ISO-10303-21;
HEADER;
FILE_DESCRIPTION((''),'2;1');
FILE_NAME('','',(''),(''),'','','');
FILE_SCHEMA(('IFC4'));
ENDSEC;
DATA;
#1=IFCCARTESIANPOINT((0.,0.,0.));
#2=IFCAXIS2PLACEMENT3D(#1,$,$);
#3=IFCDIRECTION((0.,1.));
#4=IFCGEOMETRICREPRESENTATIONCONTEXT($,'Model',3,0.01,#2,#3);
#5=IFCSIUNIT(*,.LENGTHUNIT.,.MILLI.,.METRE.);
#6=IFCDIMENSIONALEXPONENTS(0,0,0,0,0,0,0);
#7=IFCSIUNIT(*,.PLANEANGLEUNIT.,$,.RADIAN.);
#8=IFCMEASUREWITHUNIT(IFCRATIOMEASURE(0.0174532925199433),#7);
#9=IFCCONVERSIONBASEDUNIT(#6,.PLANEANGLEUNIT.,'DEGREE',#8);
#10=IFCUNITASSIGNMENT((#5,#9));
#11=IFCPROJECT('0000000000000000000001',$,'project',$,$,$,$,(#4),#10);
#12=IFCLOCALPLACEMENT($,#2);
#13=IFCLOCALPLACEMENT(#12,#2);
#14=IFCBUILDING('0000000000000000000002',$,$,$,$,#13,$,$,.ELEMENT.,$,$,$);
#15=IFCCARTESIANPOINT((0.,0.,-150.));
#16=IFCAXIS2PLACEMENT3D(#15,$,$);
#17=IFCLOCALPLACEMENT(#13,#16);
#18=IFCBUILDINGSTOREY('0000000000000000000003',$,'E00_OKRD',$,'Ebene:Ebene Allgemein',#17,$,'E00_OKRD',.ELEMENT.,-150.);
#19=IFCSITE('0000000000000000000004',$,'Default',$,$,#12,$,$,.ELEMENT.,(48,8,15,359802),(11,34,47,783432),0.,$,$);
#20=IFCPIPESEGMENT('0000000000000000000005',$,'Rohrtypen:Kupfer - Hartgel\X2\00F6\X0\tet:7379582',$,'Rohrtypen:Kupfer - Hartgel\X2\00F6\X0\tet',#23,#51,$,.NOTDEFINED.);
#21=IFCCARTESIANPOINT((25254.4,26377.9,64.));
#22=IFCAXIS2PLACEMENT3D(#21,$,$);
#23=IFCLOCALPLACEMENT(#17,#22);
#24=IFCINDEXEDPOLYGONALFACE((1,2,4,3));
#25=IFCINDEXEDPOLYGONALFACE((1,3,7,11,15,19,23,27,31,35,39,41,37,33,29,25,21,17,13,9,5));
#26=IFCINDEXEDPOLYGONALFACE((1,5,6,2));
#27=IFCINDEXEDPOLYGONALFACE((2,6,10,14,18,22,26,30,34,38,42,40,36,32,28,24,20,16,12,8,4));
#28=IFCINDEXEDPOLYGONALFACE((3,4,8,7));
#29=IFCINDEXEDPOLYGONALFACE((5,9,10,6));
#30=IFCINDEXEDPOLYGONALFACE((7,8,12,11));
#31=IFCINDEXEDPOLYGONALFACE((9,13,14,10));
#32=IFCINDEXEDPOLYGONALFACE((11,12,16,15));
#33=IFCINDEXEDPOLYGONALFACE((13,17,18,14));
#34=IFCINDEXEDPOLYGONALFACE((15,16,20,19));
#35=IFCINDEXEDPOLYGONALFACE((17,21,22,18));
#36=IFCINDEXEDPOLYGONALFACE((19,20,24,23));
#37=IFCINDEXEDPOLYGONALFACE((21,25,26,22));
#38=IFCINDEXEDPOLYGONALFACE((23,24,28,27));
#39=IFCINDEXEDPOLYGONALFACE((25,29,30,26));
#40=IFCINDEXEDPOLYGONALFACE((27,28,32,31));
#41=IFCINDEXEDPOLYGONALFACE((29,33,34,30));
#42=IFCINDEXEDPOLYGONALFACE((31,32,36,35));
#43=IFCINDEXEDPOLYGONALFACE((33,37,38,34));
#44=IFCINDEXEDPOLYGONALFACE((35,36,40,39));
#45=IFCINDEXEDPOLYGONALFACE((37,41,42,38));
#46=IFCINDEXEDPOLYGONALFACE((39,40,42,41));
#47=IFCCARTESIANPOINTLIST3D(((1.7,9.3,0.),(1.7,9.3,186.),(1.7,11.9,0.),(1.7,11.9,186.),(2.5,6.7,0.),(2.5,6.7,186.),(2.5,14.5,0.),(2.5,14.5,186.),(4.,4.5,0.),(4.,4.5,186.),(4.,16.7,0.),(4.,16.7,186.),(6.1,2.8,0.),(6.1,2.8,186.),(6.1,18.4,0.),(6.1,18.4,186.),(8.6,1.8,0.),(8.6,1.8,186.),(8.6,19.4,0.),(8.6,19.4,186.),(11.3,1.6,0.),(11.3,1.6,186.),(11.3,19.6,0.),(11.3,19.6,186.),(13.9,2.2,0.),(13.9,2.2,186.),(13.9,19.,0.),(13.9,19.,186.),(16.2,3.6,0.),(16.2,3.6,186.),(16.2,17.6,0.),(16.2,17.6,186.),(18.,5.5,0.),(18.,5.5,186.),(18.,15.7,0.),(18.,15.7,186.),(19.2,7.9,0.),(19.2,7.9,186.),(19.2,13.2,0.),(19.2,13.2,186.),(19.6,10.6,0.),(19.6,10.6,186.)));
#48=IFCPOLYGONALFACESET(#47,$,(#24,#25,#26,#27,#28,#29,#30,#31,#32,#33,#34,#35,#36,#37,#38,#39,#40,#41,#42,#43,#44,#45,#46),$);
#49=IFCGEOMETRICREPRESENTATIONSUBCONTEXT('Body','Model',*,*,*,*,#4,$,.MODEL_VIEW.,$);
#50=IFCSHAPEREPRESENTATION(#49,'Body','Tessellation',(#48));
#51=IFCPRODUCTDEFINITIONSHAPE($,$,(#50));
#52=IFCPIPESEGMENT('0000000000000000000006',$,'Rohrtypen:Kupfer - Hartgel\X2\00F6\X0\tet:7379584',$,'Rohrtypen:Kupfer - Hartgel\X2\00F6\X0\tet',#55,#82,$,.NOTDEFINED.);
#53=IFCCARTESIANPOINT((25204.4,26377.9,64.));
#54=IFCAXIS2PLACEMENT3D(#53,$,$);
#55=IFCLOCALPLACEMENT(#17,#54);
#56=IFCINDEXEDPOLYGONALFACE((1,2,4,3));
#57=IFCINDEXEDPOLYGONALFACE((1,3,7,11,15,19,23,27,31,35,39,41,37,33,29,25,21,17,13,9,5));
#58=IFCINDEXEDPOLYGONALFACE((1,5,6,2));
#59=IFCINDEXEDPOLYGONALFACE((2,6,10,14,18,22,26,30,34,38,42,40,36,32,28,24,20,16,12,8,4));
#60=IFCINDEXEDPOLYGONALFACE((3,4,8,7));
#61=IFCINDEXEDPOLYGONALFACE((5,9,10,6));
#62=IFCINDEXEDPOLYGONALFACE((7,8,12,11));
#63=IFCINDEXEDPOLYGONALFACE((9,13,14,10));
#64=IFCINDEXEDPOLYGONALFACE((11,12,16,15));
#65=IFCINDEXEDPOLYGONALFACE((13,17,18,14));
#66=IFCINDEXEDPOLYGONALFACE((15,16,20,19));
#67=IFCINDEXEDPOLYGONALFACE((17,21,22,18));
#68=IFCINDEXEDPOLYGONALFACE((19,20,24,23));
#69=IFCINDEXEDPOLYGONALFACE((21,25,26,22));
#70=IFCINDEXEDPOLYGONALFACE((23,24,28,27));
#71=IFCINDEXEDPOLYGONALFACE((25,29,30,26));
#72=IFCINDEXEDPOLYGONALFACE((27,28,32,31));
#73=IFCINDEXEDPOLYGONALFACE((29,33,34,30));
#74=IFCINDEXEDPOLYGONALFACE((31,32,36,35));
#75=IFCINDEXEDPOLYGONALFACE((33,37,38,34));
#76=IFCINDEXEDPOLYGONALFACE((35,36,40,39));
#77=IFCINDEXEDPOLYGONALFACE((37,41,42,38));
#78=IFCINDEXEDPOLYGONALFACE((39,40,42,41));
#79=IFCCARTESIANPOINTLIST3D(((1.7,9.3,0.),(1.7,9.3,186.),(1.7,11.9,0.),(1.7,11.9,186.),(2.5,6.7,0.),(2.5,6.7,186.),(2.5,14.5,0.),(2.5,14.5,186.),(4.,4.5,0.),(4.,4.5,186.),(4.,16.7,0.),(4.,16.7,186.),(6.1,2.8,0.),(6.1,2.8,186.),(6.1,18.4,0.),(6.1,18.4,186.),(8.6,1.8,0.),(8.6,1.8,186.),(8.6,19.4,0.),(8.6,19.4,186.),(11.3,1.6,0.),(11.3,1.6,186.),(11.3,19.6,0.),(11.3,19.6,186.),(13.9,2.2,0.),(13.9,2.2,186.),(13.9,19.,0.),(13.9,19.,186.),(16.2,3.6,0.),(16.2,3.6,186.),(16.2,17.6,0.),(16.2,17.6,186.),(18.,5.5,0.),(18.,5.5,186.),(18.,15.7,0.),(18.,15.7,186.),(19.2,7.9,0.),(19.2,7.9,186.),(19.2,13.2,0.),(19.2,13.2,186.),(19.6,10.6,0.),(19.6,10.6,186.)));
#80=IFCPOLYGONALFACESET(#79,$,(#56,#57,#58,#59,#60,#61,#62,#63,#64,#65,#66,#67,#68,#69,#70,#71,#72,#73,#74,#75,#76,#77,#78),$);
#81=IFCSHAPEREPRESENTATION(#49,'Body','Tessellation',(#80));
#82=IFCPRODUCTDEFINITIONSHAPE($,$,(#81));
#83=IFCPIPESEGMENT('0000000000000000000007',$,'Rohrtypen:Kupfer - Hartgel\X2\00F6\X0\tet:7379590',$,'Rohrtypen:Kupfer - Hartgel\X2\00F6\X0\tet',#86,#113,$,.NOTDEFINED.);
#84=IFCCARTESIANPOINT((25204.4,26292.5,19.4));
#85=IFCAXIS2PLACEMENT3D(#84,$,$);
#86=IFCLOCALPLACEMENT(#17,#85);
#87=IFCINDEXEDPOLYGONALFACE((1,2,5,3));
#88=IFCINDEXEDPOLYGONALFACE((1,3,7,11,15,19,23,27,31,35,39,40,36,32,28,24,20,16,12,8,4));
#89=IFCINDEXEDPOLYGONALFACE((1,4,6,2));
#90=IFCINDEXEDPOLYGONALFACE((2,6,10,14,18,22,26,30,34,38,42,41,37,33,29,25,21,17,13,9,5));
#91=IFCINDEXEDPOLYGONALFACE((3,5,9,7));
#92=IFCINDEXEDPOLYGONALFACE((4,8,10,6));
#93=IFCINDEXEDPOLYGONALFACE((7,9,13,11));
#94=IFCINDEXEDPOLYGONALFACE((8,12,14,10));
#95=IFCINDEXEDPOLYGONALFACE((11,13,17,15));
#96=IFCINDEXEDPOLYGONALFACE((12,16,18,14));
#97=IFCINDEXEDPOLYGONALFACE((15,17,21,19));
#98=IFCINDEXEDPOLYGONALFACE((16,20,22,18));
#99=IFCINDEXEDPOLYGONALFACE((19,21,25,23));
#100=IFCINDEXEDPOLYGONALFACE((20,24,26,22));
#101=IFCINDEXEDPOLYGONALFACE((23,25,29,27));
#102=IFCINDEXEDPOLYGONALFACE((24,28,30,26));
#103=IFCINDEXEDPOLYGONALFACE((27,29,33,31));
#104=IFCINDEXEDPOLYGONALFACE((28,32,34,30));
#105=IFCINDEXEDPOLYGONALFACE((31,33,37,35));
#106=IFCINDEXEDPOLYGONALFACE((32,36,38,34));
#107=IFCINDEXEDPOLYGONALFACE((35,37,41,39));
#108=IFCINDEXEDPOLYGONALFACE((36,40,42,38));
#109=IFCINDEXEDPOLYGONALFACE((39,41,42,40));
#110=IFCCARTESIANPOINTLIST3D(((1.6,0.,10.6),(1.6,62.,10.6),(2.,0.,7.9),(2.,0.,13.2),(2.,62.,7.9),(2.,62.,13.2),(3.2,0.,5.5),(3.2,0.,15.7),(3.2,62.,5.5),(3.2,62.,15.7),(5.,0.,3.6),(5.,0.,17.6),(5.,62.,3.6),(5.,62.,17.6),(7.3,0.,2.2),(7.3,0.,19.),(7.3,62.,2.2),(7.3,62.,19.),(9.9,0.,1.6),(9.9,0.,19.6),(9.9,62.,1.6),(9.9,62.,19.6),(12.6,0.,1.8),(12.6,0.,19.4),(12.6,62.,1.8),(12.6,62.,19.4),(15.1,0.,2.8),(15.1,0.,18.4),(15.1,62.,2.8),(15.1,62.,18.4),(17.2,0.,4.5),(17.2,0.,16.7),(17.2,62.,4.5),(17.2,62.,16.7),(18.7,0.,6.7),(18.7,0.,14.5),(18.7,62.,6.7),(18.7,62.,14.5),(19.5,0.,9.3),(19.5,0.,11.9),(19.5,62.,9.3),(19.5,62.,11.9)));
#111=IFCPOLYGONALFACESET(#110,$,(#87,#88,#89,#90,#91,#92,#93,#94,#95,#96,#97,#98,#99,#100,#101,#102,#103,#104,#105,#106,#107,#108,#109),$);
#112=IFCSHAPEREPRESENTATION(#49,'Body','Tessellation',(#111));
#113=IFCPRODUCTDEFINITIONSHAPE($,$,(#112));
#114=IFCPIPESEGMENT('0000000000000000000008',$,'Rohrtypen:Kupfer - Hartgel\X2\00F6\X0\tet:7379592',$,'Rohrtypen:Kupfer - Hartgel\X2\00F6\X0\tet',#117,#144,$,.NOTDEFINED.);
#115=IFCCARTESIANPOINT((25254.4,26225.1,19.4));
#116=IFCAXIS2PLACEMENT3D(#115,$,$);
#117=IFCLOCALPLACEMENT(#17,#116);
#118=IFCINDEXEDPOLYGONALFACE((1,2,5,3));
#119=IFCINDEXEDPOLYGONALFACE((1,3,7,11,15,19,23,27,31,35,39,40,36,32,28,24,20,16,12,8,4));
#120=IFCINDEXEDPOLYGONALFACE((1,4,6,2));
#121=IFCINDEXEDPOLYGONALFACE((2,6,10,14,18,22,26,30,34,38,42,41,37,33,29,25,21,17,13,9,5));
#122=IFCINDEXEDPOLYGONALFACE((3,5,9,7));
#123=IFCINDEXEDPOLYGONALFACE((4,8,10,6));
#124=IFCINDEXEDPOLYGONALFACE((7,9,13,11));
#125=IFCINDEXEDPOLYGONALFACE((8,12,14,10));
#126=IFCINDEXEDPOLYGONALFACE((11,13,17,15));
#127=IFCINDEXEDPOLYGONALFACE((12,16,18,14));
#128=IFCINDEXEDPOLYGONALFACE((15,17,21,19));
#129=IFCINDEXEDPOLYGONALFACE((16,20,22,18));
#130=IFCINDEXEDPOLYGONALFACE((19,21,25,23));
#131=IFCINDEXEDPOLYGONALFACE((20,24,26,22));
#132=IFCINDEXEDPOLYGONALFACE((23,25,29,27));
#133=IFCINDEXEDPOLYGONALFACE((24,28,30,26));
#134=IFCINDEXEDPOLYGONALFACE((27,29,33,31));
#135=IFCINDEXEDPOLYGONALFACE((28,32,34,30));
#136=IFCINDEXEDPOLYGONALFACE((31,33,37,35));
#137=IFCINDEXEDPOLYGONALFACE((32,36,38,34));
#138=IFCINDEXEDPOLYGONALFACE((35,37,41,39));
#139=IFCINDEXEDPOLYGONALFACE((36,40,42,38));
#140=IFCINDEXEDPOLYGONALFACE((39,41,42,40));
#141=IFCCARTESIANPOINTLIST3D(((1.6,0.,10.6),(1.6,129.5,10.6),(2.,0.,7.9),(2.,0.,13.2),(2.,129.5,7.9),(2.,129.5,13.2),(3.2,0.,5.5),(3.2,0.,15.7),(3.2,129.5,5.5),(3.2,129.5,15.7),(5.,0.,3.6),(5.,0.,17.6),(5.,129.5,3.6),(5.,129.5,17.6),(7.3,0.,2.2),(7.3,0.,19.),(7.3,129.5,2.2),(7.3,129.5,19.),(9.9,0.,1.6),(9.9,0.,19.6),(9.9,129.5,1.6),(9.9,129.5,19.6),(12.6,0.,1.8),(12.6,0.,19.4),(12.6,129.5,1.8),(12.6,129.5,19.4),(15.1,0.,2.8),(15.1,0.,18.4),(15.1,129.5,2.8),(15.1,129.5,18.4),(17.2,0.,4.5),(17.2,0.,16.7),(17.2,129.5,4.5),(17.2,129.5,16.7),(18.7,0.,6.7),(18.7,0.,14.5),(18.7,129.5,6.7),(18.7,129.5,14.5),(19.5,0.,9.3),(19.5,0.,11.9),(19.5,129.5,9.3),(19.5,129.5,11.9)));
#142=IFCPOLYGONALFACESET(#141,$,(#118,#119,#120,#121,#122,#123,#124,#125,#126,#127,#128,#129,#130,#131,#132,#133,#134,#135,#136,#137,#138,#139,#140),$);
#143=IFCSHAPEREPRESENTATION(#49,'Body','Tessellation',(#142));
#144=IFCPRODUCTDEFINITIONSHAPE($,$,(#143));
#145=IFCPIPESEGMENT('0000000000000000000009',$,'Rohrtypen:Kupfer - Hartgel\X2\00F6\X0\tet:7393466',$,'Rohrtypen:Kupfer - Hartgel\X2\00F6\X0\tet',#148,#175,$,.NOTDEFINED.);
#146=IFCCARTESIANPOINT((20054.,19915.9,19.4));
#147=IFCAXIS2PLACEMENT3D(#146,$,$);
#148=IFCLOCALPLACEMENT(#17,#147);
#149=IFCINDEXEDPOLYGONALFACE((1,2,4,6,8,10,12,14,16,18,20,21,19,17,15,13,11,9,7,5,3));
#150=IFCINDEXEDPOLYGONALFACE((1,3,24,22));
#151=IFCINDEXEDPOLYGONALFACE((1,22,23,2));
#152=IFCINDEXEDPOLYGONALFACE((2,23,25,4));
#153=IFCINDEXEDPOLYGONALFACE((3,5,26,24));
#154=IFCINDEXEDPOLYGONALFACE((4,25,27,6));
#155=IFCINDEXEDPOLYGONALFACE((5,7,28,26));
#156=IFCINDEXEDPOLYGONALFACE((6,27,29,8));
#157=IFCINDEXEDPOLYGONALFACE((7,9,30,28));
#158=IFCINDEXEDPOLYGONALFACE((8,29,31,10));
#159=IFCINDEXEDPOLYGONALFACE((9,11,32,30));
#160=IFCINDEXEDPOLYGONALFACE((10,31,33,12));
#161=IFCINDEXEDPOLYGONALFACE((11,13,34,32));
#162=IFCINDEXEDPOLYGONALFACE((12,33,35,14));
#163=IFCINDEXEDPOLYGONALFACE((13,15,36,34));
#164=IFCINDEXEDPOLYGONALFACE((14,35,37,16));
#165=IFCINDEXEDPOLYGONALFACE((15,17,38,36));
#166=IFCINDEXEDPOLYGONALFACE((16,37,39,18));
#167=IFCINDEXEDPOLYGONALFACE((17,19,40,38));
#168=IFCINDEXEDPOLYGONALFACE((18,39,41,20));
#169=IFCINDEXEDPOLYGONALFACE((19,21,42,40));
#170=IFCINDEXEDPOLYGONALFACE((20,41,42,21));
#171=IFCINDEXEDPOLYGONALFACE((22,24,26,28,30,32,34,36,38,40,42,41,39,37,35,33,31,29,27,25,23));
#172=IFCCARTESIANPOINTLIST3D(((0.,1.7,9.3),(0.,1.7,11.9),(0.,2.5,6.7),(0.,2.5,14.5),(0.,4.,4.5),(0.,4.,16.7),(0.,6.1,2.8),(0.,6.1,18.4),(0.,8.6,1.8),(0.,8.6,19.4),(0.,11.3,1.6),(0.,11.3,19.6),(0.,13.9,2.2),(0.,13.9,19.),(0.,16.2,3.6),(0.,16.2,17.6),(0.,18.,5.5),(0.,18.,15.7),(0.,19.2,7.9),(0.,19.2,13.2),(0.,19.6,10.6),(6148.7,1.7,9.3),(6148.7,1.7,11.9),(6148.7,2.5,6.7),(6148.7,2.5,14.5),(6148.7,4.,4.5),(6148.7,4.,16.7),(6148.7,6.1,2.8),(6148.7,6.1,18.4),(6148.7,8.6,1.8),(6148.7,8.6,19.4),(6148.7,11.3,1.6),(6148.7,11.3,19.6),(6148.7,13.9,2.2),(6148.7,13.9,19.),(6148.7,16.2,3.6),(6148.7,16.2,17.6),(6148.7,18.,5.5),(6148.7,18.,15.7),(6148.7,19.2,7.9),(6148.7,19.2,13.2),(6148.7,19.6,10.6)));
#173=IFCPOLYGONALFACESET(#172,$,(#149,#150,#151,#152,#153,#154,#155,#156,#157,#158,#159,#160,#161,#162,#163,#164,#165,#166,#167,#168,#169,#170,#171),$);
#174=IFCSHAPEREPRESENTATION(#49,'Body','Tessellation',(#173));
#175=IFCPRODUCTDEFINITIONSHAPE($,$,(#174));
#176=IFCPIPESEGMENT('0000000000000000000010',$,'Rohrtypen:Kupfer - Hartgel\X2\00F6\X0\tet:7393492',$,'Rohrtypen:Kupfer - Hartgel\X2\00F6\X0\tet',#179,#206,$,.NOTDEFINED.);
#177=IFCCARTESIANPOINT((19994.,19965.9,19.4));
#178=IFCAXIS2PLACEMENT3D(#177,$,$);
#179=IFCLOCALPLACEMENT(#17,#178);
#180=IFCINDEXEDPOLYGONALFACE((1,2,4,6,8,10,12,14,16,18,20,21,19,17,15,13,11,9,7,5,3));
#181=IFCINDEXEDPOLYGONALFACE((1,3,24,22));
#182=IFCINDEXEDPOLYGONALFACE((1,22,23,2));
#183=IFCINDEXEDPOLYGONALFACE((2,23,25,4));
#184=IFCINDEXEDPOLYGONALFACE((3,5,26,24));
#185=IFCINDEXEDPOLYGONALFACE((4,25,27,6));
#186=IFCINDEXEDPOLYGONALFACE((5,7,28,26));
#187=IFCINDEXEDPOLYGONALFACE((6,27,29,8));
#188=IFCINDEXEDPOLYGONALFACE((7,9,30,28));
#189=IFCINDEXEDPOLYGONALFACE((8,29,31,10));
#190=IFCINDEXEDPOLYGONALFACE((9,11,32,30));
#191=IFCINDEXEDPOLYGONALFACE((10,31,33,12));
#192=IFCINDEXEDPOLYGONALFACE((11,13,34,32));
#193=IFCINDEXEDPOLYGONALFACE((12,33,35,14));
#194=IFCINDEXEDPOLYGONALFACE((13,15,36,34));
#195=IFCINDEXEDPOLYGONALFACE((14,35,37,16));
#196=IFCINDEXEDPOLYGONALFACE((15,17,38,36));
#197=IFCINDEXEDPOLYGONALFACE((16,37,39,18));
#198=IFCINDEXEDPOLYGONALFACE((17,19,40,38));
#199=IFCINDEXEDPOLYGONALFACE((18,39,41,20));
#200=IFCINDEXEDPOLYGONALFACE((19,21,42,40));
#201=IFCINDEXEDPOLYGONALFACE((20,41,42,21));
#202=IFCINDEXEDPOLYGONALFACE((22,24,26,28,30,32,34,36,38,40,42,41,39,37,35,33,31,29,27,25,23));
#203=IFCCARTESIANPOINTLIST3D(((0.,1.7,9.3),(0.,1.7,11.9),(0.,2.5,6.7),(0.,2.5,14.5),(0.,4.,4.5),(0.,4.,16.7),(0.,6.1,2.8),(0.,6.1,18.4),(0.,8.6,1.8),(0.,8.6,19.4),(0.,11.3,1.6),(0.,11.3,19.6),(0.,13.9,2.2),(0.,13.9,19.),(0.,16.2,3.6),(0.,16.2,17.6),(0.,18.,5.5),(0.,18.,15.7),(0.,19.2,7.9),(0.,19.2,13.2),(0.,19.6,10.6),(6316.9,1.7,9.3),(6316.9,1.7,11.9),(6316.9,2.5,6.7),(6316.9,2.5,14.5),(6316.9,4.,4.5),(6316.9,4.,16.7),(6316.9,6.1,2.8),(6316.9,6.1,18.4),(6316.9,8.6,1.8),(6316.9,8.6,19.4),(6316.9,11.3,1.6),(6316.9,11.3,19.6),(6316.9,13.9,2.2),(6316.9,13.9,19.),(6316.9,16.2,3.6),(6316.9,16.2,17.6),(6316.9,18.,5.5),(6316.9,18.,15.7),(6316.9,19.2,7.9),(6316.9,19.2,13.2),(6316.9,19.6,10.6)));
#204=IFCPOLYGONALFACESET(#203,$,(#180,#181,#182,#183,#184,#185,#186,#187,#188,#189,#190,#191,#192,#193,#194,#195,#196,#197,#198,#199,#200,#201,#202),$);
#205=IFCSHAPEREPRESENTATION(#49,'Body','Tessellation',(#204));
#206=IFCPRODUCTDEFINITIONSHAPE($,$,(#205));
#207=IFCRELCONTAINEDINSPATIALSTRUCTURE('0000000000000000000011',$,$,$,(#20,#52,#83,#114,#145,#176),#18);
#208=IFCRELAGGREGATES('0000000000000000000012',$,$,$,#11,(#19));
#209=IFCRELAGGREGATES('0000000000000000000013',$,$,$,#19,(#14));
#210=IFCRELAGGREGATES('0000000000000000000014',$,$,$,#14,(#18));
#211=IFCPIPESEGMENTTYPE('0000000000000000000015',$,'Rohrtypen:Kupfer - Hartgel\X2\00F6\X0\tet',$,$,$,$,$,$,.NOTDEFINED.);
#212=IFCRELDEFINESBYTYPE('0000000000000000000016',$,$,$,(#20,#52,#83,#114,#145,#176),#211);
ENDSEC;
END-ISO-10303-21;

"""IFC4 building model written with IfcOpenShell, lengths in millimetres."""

from ifc_helpers import new_model, entity, si_unit, converted_unit, direction, frame, frame_2d, origin, origin_2d_with_axis, place, context, subcontext, project, spatial, circle, extrude, type_object, element, save


model = new_model("IFC4")

# Units and contexts
model_context = context("Model", 3, precision=0.01, world=origin(), true_north=direction((0.0, 1.0)))
body_context = subcontext(model_context, "Body", "Model", "MODEL_VIEW")
ifc_project = project(units=[si_unit("LENGTHUNIT", "METRE", prefix="MILLI"), converted_unit("PLANEANGLEUNIT", "DEGREE", entity("IfcRatioMeasure", 0.0174532925199433), si_unit("PLANEANGLEUNIT", "RADIAN"), dimensions=[0, 0, 0, 0, 0, 0, 0])], contexts=[model_context])

# Site, building, storey
site_placement = place(None, origin())
site = spatial("IfcSite", under=ifc_project, at=site_placement, Name="Default", CompositionType="ELEMENT", RefLatitude=(48, 8, 15, 359802), RefLongitude=(11, 34, 47, 783432), RefElevation=0.0)
building_placement = place(site_placement, origin())
building = spatial("IfcBuilding", under=site, at=building_placement, CompositionType="ELEMENT")
storey_placement = place(building_placement, frame((0.0, 0.0, -150.0)))
storey = spatial("IfcBuildingStorey", under=building, at=storey_placement, Name="E00_OKRD", ObjectType="Ebene:Ebene Allgemein", LongName="E00_OKRD", CompositionType="ELEMENT", Elevation=-150.0)

# Pipe segments
pipe_segment_type = type_object("IfcPipeSegmentType", Name="Rohrtypen:Kupfer - Hartgelötet", PredefinedType="NOTDEFINED")
for number, where, name in (
    (1, (25254.4, 26377.9, 64.0), "Rohrtypen:Kupfer - Hartgelötet:7379582"),
    (2, (25204.4, 26377.9, 64.0), "Rohrtypen:Kupfer - Hartgelötet:7379584"),
):
    element("IfcPipeSegment", number, at=place(storey_placement, frame(where)), inside=storey, type_object=pipe_segment_type, Name=name, ObjectType="Rohrtypen:Kupfer - Hartgelötet", PredefinedType="NOTDEFINED", context=body_context, shape_type="SweptSolid", body=[
        extrude(circle(Radius=9.0, at=origin_2d_with_axis()), frame((10.6, 10.6, 0.0)), (0.0, 0.0, 1.0), 186.0),
    ])
pipe_segment_1_placement = place(storey_placement, frame((25204.4, 26292.5, 19.4)))
element("IfcPipeSegment", 3, at=pipe_segment_1_placement, inside=storey, type_object=pipe_segment_type, Name="Rohrtypen:Kupfer - Hartgelötet:7379590", ObjectType="Rohrtypen:Kupfer - Hartgelötet", PredefinedType="NOTDEFINED", context=body_context, shape_type="SweptSolid", body=[
    extrude(circle(Radius=9.0, at=frame_2d((0.0, 0.0), x_axis=(1.0, 0.0))), frame((10.6, 0.0, 10.6), z_axis=(0.0, 1.0, 0.0), x_axis=(-1.0, 0.0, 0.0)), (0.0, 0.0, 1.0), 62.0),
])
pipe_segment_2_placement = place(storey_placement, frame((25254.4, 26225.1, 19.4)))
element("IfcPipeSegment", 4, at=pipe_segment_2_placement, inside=storey, type_object=pipe_segment_type, Name="Rohrtypen:Kupfer - Hartgelötet:7379592", ObjectType="Rohrtypen:Kupfer - Hartgelötet", PredefinedType="NOTDEFINED", context=body_context, shape_type="SweptSolid", body=[
    extrude(circle(Radius=9.0, at=frame_2d((0.0, 0.0), x_axis=(1.0, 0.0))), frame((10.6, 0.0, 10.6), z_axis=(0.0, 1.0, 0.0), x_axis=(-1.0, 0.0, 0.0)), (0.0, 0.0, 1.0), 129.5),
])
pipe_segment_3_placement = place(storey_placement, frame((20054.0, 19915.9, 19.4)))
element("IfcPipeSegment", 5, at=pipe_segment_3_placement, inside=storey, type_object=pipe_segment_type, Name="Rohrtypen:Kupfer - Hartgelötet:7393466", ObjectType="Rohrtypen:Kupfer - Hartgelötet", PredefinedType="NOTDEFINED", context=body_context, shape_type="SweptSolid", body=[
    extrude(circle(Radius=9.0, at=frame_2d((0.0, 0.0), x_axis=(1.0, 0.0))), frame((0.0, 10.6, 10.6), z_axis=(1.0, 0.0, 0.0), x_axis=(0.0, 1.0, 0.0)), (0.0, 0.0, 1.0), 6148.7),
])
pipe_segment_4_placement = place(storey_placement, frame((19994.0, 19965.9, 19.4)))
element("IfcPipeSegment", 6, at=pipe_segment_4_placement, inside=storey, type_object=pipe_segment_type, Name="Rohrtypen:Kupfer - Hartgelötet:7393492", ObjectType="Rohrtypen:Kupfer - Hartgelötet", PredefinedType="NOTDEFINED", context=body_context, shape_type="SweptSolid", body=[
    extrude(circle(Radius=9.0, at=frame_2d((0.0, 0.0), x_axis=(1.0, 0.0))), frame((0.0, 10.6, 10.6), z_axis=(1.0, 0.0, 0.0), x_axis=(0.0, 1.0, 0.0)), (0.0, 0.0, 1.0), 6316.9),
])

save(model, "model.ifc")
